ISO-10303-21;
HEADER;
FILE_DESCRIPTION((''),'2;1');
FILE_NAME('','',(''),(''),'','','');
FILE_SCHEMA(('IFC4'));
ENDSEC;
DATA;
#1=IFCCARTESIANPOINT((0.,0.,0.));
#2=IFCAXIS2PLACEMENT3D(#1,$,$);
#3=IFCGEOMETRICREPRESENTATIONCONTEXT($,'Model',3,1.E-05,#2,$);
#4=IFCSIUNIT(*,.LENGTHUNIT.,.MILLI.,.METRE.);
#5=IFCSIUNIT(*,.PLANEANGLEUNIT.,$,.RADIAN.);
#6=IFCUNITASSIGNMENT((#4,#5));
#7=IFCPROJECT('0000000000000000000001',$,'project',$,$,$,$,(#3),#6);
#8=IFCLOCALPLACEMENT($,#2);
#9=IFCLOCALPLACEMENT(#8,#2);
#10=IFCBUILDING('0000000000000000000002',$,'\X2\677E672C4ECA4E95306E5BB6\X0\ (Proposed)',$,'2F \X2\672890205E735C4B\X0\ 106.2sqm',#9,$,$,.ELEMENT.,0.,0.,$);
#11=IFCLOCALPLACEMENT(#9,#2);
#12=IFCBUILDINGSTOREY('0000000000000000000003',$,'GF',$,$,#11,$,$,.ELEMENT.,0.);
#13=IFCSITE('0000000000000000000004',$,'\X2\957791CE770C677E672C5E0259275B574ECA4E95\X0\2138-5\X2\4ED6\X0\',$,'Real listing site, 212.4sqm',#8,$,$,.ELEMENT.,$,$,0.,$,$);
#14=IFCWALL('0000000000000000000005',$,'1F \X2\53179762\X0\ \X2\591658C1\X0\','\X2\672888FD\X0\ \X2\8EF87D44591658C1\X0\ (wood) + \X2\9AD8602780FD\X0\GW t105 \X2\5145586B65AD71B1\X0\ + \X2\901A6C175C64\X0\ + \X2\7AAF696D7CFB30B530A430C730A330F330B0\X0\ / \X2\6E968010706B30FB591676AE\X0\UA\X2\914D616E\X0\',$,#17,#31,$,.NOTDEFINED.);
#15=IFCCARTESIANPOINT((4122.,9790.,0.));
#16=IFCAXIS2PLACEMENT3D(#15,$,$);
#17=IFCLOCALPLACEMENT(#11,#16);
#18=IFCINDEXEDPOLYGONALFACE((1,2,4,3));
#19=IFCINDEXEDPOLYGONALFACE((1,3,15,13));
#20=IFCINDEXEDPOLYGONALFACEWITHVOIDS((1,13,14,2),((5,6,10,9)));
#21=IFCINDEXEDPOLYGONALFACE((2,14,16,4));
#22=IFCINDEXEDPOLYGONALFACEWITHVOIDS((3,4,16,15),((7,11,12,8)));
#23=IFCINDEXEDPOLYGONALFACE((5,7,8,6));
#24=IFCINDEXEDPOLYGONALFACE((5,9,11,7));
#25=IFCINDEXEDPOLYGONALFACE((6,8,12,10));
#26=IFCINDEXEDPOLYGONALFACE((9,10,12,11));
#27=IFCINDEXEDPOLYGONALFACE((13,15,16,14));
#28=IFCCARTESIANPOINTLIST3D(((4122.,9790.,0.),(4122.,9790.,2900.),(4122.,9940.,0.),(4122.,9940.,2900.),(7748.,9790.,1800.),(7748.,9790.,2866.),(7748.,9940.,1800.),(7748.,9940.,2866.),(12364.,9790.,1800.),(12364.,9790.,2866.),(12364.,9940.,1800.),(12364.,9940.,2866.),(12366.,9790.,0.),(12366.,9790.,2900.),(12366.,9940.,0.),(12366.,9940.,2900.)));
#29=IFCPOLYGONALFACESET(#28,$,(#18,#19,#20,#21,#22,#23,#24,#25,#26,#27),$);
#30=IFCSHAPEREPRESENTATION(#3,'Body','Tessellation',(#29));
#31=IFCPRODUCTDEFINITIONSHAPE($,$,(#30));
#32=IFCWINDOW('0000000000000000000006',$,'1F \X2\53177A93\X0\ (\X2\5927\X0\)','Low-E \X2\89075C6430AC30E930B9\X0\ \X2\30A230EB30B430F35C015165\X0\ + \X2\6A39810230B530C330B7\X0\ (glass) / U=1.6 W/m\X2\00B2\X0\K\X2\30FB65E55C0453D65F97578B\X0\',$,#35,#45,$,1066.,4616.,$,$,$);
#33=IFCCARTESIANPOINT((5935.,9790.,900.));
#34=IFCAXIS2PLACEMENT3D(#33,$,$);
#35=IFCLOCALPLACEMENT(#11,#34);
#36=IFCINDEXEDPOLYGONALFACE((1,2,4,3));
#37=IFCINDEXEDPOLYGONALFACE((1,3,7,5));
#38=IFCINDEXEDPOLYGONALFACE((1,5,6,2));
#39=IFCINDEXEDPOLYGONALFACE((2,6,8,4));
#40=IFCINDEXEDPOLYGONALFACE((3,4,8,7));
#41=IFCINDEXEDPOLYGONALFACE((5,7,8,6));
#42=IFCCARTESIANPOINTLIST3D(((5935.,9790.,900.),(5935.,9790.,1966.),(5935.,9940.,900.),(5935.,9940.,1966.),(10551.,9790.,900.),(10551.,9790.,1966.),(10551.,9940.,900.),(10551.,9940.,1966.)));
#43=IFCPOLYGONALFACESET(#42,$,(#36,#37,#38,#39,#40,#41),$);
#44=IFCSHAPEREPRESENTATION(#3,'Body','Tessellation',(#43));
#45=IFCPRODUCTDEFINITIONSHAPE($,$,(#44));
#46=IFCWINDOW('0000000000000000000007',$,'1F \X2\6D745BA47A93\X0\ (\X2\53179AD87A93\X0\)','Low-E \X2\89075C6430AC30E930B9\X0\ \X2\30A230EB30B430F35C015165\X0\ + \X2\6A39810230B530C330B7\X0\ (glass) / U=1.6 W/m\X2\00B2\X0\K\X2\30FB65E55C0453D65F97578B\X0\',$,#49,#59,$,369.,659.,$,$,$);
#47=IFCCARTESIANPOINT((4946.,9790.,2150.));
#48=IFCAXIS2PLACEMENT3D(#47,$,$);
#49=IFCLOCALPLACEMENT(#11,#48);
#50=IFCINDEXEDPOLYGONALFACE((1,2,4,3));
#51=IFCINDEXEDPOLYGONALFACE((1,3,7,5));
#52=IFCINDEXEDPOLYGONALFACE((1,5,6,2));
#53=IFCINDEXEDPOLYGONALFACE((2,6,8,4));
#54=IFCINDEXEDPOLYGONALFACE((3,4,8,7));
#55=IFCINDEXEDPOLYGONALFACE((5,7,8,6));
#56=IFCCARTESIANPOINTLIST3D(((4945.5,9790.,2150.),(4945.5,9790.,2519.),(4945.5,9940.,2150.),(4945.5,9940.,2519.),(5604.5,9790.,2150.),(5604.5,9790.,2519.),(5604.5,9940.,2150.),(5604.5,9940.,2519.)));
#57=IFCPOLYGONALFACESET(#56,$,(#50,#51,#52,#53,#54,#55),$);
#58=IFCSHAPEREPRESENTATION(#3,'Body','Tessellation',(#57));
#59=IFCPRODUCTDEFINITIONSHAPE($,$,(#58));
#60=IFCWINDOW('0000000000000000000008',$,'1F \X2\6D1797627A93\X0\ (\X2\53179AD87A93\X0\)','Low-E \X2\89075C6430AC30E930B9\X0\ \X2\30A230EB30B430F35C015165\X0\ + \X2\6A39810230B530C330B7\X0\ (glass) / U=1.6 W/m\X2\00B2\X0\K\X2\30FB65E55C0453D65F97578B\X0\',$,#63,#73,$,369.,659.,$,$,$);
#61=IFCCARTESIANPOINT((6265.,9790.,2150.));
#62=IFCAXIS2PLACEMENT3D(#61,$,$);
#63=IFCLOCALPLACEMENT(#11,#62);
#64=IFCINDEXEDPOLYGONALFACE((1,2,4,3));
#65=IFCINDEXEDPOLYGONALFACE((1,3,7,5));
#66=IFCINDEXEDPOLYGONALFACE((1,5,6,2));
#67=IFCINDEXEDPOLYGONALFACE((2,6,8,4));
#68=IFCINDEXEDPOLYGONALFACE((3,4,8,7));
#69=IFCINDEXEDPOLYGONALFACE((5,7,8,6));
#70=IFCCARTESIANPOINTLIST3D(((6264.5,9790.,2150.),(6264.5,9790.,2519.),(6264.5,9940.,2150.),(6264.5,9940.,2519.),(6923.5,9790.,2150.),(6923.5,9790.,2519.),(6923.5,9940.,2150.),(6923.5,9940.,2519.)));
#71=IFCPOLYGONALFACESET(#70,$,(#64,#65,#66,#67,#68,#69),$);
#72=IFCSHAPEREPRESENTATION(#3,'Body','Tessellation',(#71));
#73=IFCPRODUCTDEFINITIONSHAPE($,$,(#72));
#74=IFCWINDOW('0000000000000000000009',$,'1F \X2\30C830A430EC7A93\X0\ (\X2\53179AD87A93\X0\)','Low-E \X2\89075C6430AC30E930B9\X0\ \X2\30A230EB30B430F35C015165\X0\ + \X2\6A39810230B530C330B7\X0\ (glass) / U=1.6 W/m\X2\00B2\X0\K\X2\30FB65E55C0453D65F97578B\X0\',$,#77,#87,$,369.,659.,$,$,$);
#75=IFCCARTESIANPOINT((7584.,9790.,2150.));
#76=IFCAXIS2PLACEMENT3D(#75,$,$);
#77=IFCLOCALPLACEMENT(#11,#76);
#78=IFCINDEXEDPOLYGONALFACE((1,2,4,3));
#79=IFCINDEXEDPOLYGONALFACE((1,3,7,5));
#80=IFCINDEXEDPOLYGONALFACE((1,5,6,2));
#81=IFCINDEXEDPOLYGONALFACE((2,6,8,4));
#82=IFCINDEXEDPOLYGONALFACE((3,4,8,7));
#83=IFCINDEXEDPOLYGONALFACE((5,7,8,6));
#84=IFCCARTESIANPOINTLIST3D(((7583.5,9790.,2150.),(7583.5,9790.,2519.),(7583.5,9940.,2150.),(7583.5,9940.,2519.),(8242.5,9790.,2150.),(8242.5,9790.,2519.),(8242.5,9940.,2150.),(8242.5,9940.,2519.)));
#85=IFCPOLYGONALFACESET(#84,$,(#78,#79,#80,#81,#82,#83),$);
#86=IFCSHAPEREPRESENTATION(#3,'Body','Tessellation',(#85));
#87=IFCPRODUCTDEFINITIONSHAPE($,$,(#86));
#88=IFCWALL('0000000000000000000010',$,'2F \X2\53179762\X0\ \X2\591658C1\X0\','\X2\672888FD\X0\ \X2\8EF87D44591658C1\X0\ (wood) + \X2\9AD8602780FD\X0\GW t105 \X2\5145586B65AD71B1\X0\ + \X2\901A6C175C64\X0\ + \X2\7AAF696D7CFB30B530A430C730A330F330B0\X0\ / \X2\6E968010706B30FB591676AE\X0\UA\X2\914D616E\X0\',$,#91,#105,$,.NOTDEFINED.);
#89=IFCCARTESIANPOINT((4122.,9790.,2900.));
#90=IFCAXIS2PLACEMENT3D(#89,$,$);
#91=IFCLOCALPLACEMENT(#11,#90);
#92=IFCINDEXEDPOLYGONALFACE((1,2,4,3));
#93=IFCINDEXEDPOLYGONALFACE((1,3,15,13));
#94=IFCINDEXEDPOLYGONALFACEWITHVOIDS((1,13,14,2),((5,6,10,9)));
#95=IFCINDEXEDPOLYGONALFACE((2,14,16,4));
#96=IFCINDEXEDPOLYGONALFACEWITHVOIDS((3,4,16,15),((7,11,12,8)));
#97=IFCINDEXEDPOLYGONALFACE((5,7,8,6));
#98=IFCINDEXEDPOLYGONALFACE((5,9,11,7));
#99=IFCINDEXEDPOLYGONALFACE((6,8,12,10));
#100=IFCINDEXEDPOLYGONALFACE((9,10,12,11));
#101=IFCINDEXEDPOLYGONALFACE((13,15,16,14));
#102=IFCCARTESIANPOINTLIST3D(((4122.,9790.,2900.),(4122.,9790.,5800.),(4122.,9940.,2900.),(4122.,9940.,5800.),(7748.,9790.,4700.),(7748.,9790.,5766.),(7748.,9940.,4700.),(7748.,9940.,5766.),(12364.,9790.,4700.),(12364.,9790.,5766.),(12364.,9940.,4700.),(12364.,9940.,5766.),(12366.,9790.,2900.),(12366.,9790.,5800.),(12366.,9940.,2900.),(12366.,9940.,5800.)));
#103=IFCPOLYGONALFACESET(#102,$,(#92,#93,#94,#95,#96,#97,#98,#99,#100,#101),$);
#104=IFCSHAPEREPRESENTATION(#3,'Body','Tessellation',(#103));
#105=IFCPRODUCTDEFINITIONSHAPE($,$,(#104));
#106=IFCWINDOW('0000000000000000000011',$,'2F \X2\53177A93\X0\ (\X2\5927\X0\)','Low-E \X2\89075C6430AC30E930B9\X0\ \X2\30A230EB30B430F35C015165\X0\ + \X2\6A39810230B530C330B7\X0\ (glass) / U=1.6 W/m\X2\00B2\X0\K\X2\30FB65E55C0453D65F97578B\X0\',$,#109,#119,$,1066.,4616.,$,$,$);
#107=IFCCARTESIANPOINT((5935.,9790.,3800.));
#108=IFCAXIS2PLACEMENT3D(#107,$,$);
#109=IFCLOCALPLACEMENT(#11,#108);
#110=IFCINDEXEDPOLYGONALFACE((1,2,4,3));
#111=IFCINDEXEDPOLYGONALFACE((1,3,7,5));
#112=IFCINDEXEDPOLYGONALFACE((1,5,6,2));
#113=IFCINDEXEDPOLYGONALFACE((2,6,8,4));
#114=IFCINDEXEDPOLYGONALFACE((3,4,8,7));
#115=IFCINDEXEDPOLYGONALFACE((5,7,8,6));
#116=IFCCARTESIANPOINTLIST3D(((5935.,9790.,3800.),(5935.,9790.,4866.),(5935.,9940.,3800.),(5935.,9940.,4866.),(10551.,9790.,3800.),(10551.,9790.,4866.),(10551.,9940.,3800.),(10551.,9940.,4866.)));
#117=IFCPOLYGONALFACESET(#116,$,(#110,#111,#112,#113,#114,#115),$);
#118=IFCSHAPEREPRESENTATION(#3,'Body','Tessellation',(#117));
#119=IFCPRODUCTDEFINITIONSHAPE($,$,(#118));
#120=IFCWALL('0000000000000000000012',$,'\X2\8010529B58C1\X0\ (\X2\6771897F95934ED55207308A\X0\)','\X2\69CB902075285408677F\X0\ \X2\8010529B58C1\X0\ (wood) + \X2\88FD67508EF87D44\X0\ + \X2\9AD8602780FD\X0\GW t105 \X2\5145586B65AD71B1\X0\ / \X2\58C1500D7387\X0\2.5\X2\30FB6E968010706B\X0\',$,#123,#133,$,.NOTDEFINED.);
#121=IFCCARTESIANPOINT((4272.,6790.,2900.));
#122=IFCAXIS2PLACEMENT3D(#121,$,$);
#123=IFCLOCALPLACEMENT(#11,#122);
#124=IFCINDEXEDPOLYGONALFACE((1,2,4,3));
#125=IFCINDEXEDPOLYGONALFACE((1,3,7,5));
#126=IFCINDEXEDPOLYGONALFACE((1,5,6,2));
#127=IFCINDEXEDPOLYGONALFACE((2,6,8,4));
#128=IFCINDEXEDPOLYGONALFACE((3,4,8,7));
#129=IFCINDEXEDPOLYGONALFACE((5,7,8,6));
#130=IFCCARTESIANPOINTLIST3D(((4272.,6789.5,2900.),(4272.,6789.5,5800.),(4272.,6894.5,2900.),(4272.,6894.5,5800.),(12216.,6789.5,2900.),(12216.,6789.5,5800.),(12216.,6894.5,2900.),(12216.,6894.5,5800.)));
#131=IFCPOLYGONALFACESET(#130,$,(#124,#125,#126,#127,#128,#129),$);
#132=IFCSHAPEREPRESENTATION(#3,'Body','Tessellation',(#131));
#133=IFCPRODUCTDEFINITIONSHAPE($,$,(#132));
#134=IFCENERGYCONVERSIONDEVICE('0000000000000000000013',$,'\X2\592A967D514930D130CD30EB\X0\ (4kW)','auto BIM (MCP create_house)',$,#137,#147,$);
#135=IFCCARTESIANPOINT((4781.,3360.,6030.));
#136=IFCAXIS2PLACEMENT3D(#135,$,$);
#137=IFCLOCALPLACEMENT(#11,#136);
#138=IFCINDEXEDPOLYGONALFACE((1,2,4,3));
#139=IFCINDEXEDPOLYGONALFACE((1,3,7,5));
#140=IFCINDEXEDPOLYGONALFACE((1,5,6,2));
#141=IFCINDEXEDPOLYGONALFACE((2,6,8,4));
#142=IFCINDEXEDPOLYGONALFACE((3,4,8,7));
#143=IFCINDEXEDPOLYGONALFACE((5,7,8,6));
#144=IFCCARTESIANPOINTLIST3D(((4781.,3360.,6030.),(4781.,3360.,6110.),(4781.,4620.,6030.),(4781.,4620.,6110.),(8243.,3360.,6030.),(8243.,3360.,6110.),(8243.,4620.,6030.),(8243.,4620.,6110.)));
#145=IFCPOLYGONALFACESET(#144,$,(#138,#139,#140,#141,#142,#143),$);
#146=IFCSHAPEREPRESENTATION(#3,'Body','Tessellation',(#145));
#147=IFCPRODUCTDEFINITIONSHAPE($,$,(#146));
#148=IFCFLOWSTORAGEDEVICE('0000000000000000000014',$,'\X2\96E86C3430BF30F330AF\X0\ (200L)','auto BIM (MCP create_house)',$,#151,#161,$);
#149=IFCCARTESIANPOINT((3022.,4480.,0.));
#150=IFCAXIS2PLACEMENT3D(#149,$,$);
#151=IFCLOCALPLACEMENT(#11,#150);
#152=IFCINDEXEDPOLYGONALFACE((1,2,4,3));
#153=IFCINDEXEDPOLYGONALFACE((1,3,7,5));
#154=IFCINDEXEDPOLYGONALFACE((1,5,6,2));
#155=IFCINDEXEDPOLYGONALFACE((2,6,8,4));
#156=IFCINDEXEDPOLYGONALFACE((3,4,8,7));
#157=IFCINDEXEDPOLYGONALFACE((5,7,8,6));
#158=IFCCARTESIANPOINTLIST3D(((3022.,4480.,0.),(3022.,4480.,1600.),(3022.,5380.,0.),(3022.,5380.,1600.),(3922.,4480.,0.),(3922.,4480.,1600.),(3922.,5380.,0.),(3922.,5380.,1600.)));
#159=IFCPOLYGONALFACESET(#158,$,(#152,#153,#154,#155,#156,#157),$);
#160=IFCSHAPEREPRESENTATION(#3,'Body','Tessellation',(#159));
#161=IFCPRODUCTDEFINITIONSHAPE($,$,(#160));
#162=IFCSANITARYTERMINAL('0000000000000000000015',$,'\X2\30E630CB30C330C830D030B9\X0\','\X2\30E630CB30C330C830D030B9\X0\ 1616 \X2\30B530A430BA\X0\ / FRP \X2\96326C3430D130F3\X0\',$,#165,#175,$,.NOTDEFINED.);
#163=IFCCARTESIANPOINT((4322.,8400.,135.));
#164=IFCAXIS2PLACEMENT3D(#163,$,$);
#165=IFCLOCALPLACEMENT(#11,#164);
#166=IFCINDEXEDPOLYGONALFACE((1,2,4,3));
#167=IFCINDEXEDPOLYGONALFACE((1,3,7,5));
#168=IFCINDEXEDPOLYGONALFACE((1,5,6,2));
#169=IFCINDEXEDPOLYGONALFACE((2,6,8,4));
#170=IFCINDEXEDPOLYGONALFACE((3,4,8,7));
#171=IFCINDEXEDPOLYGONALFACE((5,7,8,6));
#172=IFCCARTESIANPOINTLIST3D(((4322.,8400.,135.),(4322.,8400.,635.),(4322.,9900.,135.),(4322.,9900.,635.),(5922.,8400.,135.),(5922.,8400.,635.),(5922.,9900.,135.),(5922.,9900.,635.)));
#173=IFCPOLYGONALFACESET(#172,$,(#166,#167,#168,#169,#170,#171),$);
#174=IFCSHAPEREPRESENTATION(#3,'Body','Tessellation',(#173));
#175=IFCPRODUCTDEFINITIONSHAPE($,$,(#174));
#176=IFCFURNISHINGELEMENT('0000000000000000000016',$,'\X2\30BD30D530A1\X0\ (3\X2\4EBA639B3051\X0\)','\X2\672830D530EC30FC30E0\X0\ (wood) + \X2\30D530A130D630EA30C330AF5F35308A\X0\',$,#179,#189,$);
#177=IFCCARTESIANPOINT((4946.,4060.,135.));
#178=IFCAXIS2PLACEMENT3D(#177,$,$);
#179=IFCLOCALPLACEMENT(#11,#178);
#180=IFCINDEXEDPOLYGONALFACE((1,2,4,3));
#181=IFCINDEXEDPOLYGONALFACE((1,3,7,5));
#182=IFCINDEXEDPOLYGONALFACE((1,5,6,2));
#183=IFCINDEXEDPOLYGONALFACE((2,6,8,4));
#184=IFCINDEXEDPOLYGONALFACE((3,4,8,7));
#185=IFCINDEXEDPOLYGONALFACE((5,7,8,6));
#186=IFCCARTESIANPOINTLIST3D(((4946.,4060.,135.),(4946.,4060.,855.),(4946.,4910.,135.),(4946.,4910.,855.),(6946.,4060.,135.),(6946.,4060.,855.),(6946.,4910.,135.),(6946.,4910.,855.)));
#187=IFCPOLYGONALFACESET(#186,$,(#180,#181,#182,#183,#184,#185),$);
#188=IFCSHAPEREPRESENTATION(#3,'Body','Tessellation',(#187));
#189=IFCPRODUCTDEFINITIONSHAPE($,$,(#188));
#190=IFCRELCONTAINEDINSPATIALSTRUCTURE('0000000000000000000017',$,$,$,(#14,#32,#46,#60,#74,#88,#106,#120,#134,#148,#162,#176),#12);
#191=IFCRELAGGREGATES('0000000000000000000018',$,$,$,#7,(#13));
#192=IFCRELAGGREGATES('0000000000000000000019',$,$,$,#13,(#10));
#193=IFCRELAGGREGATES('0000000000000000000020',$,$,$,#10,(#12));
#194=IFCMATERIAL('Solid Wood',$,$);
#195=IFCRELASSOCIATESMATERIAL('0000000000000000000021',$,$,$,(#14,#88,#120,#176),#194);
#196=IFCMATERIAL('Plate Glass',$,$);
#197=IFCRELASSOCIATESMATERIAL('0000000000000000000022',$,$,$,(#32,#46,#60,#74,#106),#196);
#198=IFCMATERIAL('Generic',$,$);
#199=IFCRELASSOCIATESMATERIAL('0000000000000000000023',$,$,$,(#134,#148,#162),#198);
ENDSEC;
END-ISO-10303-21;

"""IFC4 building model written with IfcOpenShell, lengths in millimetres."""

from ifc_helpers import new_model, si_unit, frame, frame_2d, origin, place, context, project, spatial, rectangle, extrude, material, element, fill, save


model = new_model("IFC4")

# Units and contexts
model_context = context("Model", 3, precision=1e-05, world=origin())
ifc_project = project(units=[si_unit("LENGTHUNIT", "METRE", prefix="MILLI"), si_unit("PLANEANGLEUNIT", "RADIAN")], contexts=[model_context])

# Site, building, storey
site_placement = place(None, origin())
site = spatial("IfcSite", under=ifc_project, at=site_placement, Name="長野県松本市大字今井2138-5他", ObjectType="Real listing site, 212.4sqm", CompositionType="ELEMENT", RefElevation=0.0)
building_placement = place(site_placement, origin())
building = spatial("IfcBuilding", under=site, at=building_placement, Name="松本今井の家 (Proposed)", ObjectType="2F 木造平屋 106.2sqm", CompositionType="ELEMENT", ElevationOfRefHeight=0.0, ElevationOfTerrain=0.0)
storey_placement = place(building_placement, origin())
storey = spatial("IfcBuildingStorey", under=building, at=storey_placement, Name="GF", CompositionType="ELEMENT", Elevation=0.0)

# Wall, openings, windows
ifc_material_1 = material(Name="Solid Wood")
wall_1_placement = place(storey_placement, frame((4122.0, 9790.0, 0.0)))
wall_1 = element("IfcWall", 1, at=wall_1_placement, inside=storey, material=ifc_material_1, Name="1F 北面 外壁", Description="木製 軸組外壁 (wood) + 高性能GW t105 充填断熱 + 通気層 + 窯業系サイディング / 準耐火・外皮UA配慮", PredefinedType="NOTDEFINED", context=model_context, shape_type="SweptSolid", body=[
    extrude(rectangle(XDim=8244.0, YDim=150.0, at=frame_2d((4122.0, 75.0))), frame((4122.0, 9790.0, 0.0)), (0.0, 0.0, 1.0), 2900.0),
])
opening_1_placement = place(storey_placement, frame((5935.0, 9790.0, 900.0)))
opening_1 = element("IfcOpeningElement", 2, at=opening_1_placement, cuts=wall_1, PredefinedType="NOTDEFINED", context=model_context, shape_type="SweptSolid", body=[
    extrude(rectangle(XDim=4616.0, YDim=150.0, at=frame_2d((2308.0, 75.0))), frame((5935.0, 9790.0, 900.0)), (0.0, 0.0, 1.0), 1066.0),
])
opening_2_placement = place(storey_placement, frame((4946.0, 9790.0, 2150.0)))
opening_2 = element("IfcOpeningElement", 3, at=opening_2_placement, cuts=wall_1, PredefinedType="NOTDEFINED", context=model_context, shape_type="SweptSolid", body=[
    extrude(rectangle(XDim=659.0, YDim=150.0, at=frame_2d((329.0, 75.0))), frame((4946.0, 9790.0, 2150.0)), (0.0, 0.0, 1.0), 369.0),
])
opening_3_placement = place(storey_placement, frame((6265.0, 9790.0, 2150.0)))
opening_3 = element("IfcOpeningElement", 4, at=opening_3_placement, cuts=wall_1, PredefinedType="NOTDEFINED", context=model_context, shape_type="SweptSolid", body=[
    extrude(rectangle(XDim=659.0, YDim=150.0, at=frame_2d((329.0, 75.0))), frame((6265.0, 9790.0, 2150.0)), (0.0, 0.0, 1.0), 369.0),
])
opening_4_placement = place(storey_placement, frame((7584.0, 9790.0, 2150.0)))
opening_4 = element("IfcOpeningElement", 5, at=opening_4_placement, cuts=wall_1, PredefinedType="NOTDEFINED", context=model_context, shape_type="SweptSolid", body=[
    extrude(rectangle(XDim=659.0, YDim=150.0, at=frame_2d((329.0, 75.0))), frame((7584.0, 9790.0, 2150.0)), (0.0, 0.0, 1.0), 369.0),
])
ifc_material_2 = material(Name="Plate Glass")
window_1_placement = place(storey_placement, frame((5935.0, 9790.0, 900.0)))
window_1 = element("IfcWindow", 6, at=window_1_placement, inside=storey, material=ifc_material_2, Name="1F 北窓 (大)", Description="Low-E 複層ガラス アルゴン封入 + 樹脂サッシ (glass) / U=1.6 W/m²K・日射取得型", OverallHeight=1066.0, OverallWidth=4616.0, context=model_context, shape_type="SweptSolid", body=[
    extrude(rectangle(XDim=4616.0, YDim=150.0, at=frame_2d((2308.0, 75.0))), frame((5935.0, 9790.0, 900.0)), (0.0, 0.0, 1.0), 1066.0),
])
fill(opening_1, window_1)
window_2_placement = place(storey_placement, frame((4946.0, 9790.0, 2150.0)))
window_2 = element("IfcWindow", 7, at=window_2_placement, inside=storey, material=ifc_material_2, Name="1F 浴室窓 (北高窓)", Description="Low-E 複層ガラス アルゴン封入 + 樹脂サッシ (glass) / U=1.6 W/m²K・日射取得型", OverallHeight=369.0, OverallWidth=659.0, context=model_context, shape_type="SweptSolid", body=[
    extrude(rectangle(XDim=659.0, YDim=150.0, at=frame_2d((329.0, 75.0))), frame((4946.0, 9790.0, 2150.0)), (0.0, 0.0, 1.0), 369.0),
])
fill(opening_2, window_2)
window_3_placement = place(storey_placement, frame((6265.0, 9790.0, 2150.0)))
window_3 = element("IfcWindow", 8, at=window_3_placement, inside=storey, material=ifc_material_2, Name="1F 洗面窓 (北高窓)", Description="Low-E 複層ガラス アルゴン封入 + 樹脂サッシ (glass) / U=1.6 W/m²K・日射取得型", OverallHeight=369.0, OverallWidth=659.0, context=model_context, shape_type="SweptSolid", body=[
    extrude(rectangle(XDim=659.0, YDim=150.0, at=frame_2d((329.0, 75.0))), frame((6265.0, 9790.0, 2150.0)), (0.0, 0.0, 1.0), 369.0),
])
fill(opening_3, window_3)
window_4_placement = place(storey_placement, frame((7584.0, 9790.0, 2150.0)))
window_4 = element("IfcWindow", 9, at=window_4_placement, inside=storey, material=ifc_material_2, Name="1F トイレ窓 (北高窓)", Description="Low-E 複層ガラス アルゴン封入 + 樹脂サッシ (glass) / U=1.6 W/m²K・日射取得型", OverallHeight=369.0, OverallWidth=659.0, context=model_context, shape_type="SweptSolid", body=[
    extrude(rectangle(XDim=659.0, YDim=150.0, at=frame_2d((329.0, 75.0))), frame((7584.0, 9790.0, 2150.0)), (0.0, 0.0, 1.0), 369.0),
])
fill(opening_4, window_4)

# Wall, opening, window
wall_2_placement = place(storey_placement, frame((4122.0, 9790.0, 2900.0)))
wall_2 = element("IfcWall", 10, at=wall_2_placement, inside=storey, material=ifc_material_1, Name="2F 北面 外壁", Description="木製 軸組外壁 (wood) + 高性能GW t105 充填断熱 + 通気層 + 窯業系サイディング / 準耐火・外皮UA配慮", PredefinedType="NOTDEFINED", context=model_context, shape_type="SweptSolid", body=[
    extrude(rectangle(XDim=8244.0, YDim=150.0, at=frame_2d((4122.0, 75.0))), frame((4122.0, 9790.0, 2900.0)), (0.0, 0.0, 1.0), 2900.0),
])
opening_5_placement = place(storey_placement, frame((5935.0, 9790.0, 3800.0)))
opening_5 = element("IfcOpeningElement", 11, at=opening_5_placement, cuts=wall_2, PredefinedType="NOTDEFINED", context=model_context, shape_type="SweptSolid", body=[
    extrude(rectangle(XDim=4616.0, YDim=150.0, at=frame_2d((2308.0, 75.0))), frame((5935.0, 9790.0, 3800.0)), (0.0, 0.0, 1.0), 1066.0),
])
window_5_placement = place(storey_placement, frame((5935.0, 9790.0, 3800.0)))
window_5 = element("IfcWindow", 12, at=window_5_placement, inside=storey, material=ifc_material_2, Name="2F 北窓 (大)", Description="Low-E 複層ガラス アルゴン封入 + 樹脂サッシ (glass) / U=1.6 W/m²K・日射取得型", OverallHeight=1066.0, OverallWidth=4616.0, context=model_context, shape_type="SweptSolid", body=[
    extrude(rectangle(XDim=4616.0, YDim=150.0, at=frame_2d((2308.0, 75.0))), frame((5935.0, 9790.0, 3800.0)), (0.0, 0.0, 1.0), 1066.0),
])
fill(opening_5, window_5)

# Wall
wall_3_placement = place(storey_placement, frame((4272.0, 6790.0, 2900.0)))
element("IfcWall", 13, at=wall_3_placement, inside=storey, material=ifc_material_1, Name="耐力壁 (東西間仕切り)", Description="構造用合板 耐力壁 (wood) + 製材軸組 + 高性能GW t105 充填断熱 / 壁倍率2.5・準耐火", PredefinedType="NOTDEFINED", context=model_context, shape_type="SweptSolid", body=[
    extrude(rectangle(XDim=7944.0, YDim=105.0, at=frame_2d((3972.0, 52.0))), frame((4272.0, 6790.0, 2900.0)), (0.0, 0.0, 1.0), 2900.0),
])

# Energy conversion device
ifc_material_3 = material(Name="Generic")
energy_conversion_device_placement = place(storey_placement, frame((4781.0, 3360.0, 6030.0)))
element("IfcEnergyConversionDevice", 14, at=energy_conversion_device_placement, inside=storey, material=ifc_material_3, Name="太陽光パネル (4kW)", Description="auto BIM (MCP create_house)", context=model_context, shape_type="SweptSolid", body=[
    extrude(rectangle(XDim=3462.0, YDim=1260.0, at=frame_2d((1731.0, 630.0))), frame((4781.0, 3360.0, 6030.0)), (0.0, 0.0, 1.0), 80.0),
])

# Flow storage device
flow_storage_device_placement = place(storey_placement, frame((3022.0, 4480.0, 0.0)))
element("IfcFlowStorageDevice", 15, at=flow_storage_device_placement, inside=storey, material=ifc_material_3, Name="雨水タンク (200L)", Description="auto BIM (MCP create_house)", context=model_context, shape_type="SweptSolid", body=[
    extrude(rectangle(XDim=900.0, YDim=900.0, at=frame_2d((450.0, 450.0))), frame((3022.0, 4480.0, 0.0)), (0.0, 0.0, 1.0), 1600.0),
])

# Sanitary terminal
sanitary_terminal_placement = place(storey_placement, frame((4322.0, 8400.0, 135.0)))
element("IfcSanitaryTerminal", 16, at=sanitary_terminal_placement, inside=storey, material=ifc_material_3, Name="ユニットバス", Description="ユニットバス 1616 サイズ / FRP 防水パン", PredefinedType="NOTDEFINED", context=model_context, shape_type="SweptSolid", body=[
    extrude(rectangle(XDim=1600.0, YDim=1500.0, at=frame_2d((800.0, 750.0))), frame((4322.0, 8400.0, 135.0)), (0.0, 0.0, 1.0), 500.0),
])

# Furnishing element
furnishing_1_placement = place(storey_placement, frame((4946.0, 4060.0, 135.0)))
element("IfcFurnishingElement", 17, at=furnishing_1_placement, inside=storey, material=ifc_material_1, Name="ソファ (3人掛け)", Description="木フレーム (wood) + ファブリック張り", context=model_context, shape_type="SweptSolid", body=[
    extrude(rectangle(XDim=2000.0, YDim=850.0, at=frame_2d((1000.0, 425.0))), frame((4946.0, 4060.0, 135.0)), (0.0, 0.0, 1.0), 720.0),
])

save(model, "model.ifc")
